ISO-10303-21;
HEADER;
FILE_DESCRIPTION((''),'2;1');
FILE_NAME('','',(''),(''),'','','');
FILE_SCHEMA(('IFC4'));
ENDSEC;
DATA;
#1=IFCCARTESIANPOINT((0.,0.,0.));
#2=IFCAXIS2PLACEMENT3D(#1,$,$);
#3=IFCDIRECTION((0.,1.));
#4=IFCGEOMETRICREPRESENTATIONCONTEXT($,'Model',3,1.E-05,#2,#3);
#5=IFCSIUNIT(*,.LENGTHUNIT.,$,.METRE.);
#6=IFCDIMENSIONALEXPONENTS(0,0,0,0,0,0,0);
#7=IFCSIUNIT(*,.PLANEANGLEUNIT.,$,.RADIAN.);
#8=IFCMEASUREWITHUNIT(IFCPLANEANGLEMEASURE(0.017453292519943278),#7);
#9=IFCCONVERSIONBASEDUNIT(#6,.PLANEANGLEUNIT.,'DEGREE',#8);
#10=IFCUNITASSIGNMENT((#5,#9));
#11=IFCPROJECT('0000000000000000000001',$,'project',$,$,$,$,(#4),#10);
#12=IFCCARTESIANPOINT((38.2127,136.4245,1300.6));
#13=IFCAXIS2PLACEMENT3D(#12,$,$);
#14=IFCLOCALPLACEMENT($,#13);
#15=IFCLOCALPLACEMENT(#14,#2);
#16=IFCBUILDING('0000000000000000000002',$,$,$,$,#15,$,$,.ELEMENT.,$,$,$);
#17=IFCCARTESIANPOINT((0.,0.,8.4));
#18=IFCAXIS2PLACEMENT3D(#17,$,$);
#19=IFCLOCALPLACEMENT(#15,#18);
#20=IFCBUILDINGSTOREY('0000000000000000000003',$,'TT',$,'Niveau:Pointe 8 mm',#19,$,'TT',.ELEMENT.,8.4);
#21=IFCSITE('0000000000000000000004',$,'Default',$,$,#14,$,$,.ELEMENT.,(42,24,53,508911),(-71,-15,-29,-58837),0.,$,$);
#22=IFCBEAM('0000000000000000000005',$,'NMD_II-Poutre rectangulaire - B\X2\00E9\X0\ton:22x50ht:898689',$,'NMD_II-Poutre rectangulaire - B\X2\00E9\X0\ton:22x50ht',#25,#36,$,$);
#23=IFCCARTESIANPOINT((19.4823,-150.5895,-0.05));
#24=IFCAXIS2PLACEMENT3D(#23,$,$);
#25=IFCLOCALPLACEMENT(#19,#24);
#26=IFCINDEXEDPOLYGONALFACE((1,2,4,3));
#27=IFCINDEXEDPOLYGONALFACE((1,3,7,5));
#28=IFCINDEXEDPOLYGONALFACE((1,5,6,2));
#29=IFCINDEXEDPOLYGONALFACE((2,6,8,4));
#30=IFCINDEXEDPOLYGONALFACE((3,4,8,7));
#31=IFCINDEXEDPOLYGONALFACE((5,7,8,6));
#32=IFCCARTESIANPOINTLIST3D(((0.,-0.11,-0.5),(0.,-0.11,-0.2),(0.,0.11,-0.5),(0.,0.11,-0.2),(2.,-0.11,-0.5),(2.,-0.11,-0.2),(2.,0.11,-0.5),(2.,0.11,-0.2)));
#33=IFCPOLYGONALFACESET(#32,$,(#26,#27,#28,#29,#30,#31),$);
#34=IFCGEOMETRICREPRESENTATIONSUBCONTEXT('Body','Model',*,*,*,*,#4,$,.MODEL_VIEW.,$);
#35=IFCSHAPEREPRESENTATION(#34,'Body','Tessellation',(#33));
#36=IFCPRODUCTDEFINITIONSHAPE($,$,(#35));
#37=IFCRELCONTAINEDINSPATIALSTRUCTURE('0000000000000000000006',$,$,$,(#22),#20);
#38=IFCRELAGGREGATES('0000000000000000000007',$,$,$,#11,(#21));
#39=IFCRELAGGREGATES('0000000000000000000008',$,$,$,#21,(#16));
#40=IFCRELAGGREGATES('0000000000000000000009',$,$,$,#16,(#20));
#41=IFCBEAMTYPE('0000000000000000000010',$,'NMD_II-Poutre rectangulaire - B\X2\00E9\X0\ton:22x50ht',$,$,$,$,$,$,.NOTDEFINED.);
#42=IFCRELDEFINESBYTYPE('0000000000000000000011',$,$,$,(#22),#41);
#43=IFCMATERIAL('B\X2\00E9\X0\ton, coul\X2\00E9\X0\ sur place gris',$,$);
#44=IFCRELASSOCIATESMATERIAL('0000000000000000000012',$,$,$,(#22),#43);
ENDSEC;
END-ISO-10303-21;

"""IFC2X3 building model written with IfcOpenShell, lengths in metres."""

from ifc_helpers import new_model, entity, si_unit, converted_unit, direction, frame, frame_2d, origin, place, context, subcontext, project, spatial, rectangle, extrude, material, type_object, element, save


model = new_model("IFC2X3")

# Units and contexts
model_context = context("Model", 3, precision=1e-05, world=origin(), true_north=direction((0.0, 1.0)))
body_context = subcontext(model_context, "Body", "Model", "MODEL_VIEW")
ifc_project = project(units=[si_unit("LENGTHUNIT", "METRE"), converted_unit("PLANEANGLEUNIT", "DEGREE", entity("IfcPlaneAngleMeasure", 0.017453292519943278), si_unit("PLANEANGLEUNIT", "RADIAN"), dimensions=[0, 0, 0, 0, 0, 0, 0])], contexts=[model_context])

# Site, building, storey
site_placement = place(None, frame((38.2127, 136.4245, 1300.6)))
site = spatial("IfcSite", under=ifc_project, at=site_placement, Name="Default", CompositionType="ELEMENT", RefLatitude=(42, 24, 53, 508911), RefLongitude=(-71, -15, -29, -58837), RefElevation=0.0)
building_placement = place(site_placement, origin())
building = spatial("IfcBuilding", under=site, at=building_placement, CompositionType="ELEMENT")
storey_placement = place(building_placement, frame((0.0, 0.0, 8.4)))
storey = spatial("IfcBuildingStorey", under=building, at=storey_placement, Name="TT", ObjectType="Niveau:Pointe 8 mm", LongName="TT", CompositionType="ELEMENT", Elevation=8.4)

# Beam
ifc_material_1 = material(Name="Béton, coulé sur place gris")
beam_type_1 = type_object("IfcBeamType", Name="NMD_II-Poutre rectangulaire - Béton:22x50ht", PredefinedType="NOTDEFINED")
beam_1_placement = place(storey_placement, frame((19.4823, -150.5895, -0.05)))
element("IfcBeam", 1, at=beam_1_placement, inside=storey, type_object=beam_type_1, material=ifc_material_1, Name="NMD_II-Poutre rectangulaire - Béton:22x50ht:898689", ObjectType="NMD_II-Poutre rectangulaire - Béton:22x50ht", context=body_context, shape_type="SweptSolid", body=[
    extrude(rectangle(XDim=0.3, YDim=0.22, at=frame_2d((0.0, 0.0), x_axis=(1.0, 0.0))), frame((0.0, 0.0, -0.35), z_axis=(1.0, 0.0, 0.0), x_axis=(0.0, 0.0, -1.0)), (0.0, 0.0, 1.0), 2.0),
])

save(model, "model.ifc")
